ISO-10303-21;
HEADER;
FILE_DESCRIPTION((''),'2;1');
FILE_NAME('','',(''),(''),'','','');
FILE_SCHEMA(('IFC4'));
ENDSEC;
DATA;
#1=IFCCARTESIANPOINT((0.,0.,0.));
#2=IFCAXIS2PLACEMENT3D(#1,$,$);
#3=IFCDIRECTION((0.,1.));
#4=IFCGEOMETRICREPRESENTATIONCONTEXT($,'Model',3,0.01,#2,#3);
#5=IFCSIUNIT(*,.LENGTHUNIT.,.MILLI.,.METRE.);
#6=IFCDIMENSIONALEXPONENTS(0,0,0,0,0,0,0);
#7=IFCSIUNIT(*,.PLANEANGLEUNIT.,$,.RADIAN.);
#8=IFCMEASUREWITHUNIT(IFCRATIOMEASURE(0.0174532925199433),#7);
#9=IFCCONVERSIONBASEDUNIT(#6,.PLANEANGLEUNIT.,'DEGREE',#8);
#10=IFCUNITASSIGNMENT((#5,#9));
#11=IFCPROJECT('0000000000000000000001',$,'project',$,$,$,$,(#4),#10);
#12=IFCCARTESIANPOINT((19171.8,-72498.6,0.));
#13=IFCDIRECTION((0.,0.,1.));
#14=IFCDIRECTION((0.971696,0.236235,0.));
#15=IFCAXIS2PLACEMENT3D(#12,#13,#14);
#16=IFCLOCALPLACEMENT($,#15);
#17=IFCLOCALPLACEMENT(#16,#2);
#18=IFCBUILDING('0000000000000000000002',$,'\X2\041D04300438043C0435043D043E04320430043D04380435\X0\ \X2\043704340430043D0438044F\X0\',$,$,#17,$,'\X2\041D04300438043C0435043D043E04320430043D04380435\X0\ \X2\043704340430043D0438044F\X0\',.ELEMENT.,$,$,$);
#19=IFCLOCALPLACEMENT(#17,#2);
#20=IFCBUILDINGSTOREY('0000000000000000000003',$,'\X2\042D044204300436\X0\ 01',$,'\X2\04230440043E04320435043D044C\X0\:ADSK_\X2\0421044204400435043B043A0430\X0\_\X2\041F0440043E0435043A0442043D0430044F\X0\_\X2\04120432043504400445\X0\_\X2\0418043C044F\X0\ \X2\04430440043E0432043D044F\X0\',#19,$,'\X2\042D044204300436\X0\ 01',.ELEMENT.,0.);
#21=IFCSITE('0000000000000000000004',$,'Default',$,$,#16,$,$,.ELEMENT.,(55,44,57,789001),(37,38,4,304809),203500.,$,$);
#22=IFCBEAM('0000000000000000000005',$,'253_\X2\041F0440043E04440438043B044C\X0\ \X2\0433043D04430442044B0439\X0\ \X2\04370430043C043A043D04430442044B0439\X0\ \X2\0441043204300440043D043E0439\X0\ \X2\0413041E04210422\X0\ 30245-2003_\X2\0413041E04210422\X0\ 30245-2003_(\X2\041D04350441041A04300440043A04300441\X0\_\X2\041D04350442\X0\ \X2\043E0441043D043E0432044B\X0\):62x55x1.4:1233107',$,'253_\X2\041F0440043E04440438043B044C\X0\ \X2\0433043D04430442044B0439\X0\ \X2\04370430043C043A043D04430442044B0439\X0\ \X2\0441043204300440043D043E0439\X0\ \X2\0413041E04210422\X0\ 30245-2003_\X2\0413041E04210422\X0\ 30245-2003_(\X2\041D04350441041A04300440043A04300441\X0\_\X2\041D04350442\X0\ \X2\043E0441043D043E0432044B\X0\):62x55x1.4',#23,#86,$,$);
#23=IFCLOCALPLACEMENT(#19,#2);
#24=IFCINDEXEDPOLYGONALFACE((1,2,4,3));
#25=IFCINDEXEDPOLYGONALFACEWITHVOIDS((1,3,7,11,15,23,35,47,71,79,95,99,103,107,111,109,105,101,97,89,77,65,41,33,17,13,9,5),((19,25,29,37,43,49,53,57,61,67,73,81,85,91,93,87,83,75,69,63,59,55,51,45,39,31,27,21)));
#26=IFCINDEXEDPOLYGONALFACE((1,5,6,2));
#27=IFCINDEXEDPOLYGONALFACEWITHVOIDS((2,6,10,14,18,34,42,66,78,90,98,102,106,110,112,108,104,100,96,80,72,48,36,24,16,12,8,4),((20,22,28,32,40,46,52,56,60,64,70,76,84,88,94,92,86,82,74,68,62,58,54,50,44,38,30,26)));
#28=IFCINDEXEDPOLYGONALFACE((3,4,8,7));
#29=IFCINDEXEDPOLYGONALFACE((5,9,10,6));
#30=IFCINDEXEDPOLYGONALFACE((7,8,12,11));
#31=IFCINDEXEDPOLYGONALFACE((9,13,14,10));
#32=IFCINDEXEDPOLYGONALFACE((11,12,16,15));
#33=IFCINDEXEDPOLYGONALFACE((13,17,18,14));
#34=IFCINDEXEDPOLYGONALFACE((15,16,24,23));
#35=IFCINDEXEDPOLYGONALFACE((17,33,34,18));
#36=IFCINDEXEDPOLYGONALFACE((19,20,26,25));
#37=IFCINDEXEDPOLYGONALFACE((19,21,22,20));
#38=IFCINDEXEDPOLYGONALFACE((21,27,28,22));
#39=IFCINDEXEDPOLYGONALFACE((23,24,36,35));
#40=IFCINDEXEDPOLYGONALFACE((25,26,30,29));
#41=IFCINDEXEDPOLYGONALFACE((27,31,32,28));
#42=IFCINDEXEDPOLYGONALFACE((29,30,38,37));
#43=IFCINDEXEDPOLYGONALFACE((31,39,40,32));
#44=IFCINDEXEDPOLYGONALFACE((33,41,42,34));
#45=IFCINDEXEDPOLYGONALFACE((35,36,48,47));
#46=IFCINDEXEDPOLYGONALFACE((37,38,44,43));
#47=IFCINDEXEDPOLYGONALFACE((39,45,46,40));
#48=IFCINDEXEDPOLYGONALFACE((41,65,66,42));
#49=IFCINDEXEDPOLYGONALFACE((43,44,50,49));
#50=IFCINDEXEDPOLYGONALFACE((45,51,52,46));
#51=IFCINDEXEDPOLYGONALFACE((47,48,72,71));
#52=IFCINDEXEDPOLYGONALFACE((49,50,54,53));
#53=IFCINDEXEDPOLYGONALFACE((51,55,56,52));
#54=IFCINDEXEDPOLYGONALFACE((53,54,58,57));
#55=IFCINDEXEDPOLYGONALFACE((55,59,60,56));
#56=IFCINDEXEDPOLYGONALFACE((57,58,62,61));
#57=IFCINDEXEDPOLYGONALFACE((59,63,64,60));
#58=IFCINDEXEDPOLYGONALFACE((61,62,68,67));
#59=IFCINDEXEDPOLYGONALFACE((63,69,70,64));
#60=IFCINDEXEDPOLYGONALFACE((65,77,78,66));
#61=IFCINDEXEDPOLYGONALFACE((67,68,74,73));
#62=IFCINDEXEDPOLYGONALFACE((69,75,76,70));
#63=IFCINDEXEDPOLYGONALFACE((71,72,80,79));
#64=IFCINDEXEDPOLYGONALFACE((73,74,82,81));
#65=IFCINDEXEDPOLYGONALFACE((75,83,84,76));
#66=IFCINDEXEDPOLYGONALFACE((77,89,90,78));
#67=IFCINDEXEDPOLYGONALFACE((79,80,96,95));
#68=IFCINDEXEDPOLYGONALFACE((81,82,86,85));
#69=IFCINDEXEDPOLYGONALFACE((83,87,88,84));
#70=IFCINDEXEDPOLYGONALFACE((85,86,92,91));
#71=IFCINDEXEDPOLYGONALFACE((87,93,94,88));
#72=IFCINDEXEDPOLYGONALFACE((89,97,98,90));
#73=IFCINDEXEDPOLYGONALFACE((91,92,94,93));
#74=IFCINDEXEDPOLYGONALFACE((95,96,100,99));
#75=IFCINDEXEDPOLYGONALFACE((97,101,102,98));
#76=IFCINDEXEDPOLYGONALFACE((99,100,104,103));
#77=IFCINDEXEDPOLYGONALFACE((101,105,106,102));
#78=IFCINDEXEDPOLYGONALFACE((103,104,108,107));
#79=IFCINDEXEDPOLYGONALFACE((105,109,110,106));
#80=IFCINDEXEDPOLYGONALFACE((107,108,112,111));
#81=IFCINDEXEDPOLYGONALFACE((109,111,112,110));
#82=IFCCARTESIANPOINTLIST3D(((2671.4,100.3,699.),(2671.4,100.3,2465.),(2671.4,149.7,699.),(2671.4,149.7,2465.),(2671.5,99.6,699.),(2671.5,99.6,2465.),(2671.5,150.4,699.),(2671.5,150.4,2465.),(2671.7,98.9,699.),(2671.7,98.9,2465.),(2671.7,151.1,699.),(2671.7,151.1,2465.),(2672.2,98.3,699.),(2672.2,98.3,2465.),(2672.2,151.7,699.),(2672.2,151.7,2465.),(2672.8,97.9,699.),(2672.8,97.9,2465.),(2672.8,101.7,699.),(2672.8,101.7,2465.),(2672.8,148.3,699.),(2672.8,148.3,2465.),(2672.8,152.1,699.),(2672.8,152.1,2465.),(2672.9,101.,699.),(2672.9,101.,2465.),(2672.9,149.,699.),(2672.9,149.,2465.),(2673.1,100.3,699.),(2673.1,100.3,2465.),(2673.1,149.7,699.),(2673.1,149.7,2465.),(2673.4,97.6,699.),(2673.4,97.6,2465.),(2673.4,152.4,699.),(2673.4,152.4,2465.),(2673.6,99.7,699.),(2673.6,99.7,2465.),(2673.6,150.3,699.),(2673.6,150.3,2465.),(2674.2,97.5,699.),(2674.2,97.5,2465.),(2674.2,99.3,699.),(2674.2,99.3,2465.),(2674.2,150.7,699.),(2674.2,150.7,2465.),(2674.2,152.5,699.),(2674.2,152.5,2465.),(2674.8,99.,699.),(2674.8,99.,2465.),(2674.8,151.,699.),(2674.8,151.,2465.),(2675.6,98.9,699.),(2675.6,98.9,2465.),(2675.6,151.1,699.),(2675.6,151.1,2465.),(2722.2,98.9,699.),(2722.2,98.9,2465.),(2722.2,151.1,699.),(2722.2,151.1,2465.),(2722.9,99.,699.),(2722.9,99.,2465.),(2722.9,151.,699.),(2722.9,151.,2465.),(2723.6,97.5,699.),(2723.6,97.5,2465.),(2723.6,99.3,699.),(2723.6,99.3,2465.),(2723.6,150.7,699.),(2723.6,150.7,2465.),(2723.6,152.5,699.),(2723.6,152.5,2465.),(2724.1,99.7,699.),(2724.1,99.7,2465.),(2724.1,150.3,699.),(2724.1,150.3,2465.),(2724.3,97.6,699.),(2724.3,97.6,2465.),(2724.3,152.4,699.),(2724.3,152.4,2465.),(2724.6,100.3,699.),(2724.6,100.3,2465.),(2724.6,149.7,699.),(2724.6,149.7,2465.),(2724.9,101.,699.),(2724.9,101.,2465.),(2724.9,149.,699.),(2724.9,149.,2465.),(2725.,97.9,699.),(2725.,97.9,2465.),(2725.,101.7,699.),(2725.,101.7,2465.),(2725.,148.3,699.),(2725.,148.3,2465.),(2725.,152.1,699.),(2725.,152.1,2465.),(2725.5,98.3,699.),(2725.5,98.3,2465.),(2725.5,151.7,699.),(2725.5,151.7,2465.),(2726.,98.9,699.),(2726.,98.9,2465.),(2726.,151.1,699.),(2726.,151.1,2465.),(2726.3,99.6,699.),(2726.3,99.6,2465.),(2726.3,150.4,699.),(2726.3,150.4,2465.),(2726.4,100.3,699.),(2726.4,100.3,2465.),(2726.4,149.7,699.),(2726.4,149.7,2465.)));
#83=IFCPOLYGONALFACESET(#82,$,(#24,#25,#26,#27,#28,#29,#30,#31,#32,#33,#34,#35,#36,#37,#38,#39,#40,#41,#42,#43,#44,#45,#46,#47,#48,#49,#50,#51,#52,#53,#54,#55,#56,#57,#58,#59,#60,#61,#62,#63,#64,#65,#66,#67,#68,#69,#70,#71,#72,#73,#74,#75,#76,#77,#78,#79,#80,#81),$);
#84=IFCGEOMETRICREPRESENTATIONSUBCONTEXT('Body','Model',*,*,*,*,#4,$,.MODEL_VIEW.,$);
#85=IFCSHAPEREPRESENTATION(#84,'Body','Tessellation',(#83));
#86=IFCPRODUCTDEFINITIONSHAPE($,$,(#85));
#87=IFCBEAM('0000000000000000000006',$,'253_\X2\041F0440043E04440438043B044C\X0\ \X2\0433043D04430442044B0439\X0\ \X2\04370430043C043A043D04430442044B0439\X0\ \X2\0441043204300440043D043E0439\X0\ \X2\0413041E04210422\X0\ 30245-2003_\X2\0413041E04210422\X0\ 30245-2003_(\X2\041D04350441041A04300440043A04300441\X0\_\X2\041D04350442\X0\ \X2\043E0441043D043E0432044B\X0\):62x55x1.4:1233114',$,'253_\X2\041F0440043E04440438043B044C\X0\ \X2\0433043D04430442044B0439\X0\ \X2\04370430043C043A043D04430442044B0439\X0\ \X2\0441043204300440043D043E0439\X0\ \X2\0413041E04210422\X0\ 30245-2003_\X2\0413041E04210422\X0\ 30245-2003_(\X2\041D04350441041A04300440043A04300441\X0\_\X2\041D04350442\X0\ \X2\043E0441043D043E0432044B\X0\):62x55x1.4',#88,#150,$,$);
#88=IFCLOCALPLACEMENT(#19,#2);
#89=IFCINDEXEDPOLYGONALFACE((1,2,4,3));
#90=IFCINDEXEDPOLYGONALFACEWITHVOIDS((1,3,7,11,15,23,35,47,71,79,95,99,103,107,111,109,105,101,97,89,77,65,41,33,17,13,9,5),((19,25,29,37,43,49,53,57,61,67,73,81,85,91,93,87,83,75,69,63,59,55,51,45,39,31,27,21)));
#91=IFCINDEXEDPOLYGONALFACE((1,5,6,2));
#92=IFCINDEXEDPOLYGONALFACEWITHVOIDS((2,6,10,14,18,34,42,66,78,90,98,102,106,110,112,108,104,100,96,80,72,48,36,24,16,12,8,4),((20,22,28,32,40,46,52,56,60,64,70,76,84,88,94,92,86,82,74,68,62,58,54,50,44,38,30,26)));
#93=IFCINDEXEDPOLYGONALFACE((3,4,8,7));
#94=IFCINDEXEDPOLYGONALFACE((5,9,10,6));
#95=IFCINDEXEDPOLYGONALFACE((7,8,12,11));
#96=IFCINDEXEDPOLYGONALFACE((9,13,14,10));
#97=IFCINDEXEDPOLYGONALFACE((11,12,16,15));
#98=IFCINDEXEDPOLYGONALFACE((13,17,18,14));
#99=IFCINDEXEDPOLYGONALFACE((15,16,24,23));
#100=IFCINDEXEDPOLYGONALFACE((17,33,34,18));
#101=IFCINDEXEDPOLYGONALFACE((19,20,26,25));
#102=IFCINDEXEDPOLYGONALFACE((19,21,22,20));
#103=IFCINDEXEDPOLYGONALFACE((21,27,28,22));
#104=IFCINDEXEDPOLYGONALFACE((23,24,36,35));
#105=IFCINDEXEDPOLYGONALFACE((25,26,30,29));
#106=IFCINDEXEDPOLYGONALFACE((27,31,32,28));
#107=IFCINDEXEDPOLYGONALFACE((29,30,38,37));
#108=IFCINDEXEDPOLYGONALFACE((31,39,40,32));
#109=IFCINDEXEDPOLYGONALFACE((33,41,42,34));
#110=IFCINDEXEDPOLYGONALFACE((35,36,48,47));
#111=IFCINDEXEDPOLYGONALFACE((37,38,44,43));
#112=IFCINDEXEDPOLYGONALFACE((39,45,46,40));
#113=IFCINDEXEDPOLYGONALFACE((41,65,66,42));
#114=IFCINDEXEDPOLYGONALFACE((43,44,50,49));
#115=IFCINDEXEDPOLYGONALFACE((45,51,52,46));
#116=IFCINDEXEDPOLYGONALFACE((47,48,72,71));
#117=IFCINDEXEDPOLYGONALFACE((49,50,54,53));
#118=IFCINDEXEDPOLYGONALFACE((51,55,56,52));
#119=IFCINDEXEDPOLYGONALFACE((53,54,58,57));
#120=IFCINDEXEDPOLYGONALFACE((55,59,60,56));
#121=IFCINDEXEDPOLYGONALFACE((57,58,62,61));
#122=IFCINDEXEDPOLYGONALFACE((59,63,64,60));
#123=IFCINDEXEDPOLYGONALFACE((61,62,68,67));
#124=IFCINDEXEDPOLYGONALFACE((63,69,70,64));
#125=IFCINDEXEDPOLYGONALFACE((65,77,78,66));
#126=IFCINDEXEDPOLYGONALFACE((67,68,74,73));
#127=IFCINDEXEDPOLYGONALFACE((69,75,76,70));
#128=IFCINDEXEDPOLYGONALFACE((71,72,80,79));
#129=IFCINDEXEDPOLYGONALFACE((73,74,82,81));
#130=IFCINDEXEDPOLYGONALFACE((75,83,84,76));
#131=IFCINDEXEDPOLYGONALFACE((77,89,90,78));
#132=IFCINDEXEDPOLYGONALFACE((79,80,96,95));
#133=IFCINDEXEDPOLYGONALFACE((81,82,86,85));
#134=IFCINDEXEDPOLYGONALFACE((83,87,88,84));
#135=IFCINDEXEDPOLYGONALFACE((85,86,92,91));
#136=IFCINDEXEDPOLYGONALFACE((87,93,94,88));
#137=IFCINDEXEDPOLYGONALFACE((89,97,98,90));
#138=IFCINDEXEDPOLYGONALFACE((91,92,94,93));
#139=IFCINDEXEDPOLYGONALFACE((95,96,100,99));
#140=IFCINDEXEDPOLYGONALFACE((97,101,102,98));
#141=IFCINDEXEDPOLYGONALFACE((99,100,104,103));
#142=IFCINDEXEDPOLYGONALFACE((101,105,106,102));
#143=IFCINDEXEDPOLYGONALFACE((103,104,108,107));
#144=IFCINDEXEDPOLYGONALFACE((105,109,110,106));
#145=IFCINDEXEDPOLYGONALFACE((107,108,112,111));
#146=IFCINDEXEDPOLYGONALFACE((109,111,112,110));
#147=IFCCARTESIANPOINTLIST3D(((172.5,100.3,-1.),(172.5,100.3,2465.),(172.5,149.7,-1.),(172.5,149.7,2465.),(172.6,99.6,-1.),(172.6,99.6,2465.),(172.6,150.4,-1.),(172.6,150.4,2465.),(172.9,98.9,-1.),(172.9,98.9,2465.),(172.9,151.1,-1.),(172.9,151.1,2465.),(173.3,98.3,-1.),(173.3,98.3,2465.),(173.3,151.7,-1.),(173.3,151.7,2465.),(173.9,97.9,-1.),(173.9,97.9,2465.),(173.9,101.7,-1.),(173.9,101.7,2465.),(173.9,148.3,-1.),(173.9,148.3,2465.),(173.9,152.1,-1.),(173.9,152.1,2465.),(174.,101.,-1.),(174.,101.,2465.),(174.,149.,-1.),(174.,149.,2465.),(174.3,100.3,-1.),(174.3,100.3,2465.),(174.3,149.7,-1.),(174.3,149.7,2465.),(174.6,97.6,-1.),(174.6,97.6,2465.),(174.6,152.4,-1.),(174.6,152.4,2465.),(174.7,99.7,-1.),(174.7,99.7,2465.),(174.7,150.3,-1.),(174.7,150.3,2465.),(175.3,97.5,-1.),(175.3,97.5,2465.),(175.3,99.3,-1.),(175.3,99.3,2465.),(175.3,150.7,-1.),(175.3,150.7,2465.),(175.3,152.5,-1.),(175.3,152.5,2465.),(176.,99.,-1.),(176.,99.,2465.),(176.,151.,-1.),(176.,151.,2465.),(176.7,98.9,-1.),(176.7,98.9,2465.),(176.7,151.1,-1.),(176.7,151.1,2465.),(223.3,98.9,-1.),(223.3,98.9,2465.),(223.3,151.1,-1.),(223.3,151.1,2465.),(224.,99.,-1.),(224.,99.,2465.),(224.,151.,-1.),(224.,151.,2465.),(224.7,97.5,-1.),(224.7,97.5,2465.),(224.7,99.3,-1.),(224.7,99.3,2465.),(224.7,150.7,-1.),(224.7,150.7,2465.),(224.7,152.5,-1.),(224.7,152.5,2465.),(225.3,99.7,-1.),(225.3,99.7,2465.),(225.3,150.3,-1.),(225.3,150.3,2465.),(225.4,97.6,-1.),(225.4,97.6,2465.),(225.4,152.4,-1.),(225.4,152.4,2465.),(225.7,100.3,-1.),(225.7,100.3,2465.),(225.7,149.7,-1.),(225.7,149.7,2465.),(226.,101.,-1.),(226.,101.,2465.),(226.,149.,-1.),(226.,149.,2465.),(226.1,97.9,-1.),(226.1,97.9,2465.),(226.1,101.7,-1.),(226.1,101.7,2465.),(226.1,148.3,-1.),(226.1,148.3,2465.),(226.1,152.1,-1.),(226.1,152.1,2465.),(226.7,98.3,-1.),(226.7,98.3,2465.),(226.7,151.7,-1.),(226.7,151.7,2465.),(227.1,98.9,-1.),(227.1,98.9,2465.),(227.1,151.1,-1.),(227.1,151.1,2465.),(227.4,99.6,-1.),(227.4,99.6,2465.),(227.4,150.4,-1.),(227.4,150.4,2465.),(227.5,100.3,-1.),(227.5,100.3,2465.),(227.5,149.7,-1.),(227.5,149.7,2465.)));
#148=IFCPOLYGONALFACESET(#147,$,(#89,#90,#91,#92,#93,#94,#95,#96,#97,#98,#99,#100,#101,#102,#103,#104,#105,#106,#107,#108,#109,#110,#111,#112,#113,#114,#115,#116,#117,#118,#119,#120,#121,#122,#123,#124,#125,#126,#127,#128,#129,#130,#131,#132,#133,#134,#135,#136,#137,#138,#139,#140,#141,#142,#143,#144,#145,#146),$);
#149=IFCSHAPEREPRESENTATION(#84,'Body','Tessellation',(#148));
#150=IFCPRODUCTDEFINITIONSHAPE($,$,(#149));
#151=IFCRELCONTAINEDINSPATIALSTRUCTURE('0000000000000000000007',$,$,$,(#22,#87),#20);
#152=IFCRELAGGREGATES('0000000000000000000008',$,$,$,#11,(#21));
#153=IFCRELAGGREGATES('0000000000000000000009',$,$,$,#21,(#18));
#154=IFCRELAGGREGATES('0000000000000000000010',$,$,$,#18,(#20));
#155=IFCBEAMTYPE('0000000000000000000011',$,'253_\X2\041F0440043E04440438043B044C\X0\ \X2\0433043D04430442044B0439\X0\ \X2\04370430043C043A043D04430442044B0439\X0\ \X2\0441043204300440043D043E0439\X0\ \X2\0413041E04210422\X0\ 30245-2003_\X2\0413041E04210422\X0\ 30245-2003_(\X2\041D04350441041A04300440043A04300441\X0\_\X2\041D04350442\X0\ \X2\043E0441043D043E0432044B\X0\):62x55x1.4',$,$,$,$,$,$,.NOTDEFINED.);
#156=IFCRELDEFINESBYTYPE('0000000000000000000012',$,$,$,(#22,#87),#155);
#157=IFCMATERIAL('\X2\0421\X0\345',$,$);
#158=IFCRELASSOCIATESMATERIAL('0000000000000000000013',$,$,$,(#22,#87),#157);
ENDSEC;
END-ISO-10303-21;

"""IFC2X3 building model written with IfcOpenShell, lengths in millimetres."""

from ifc_helpers import new_model, entity, si_unit, converted_unit, direction, frame, frame_2d, origin, place, context, subcontext, project, spatial, polyline, circle_curve, parameter, trimmed, segment, composite_curve, outline, extrude, material, type_object, element, save


model = new_model("IFC2X3")

# Units and contexts
model_context = context("Model", 3, precision=0.01, world=origin(), true_north=direction((0.0, 1.0)))
body_context = subcontext(model_context, "Body", "Model", "MODEL_VIEW")
ifc_project = project(units=[si_unit("LENGTHUNIT", "METRE", prefix="MILLI"), converted_unit("PLANEANGLEUNIT", "DEGREE", entity("IfcRatioMeasure", 0.0174532925199433), si_unit("PLANEANGLEUNIT", "RADIAN"), dimensions=[0, 0, 0, 0, 0, 0, 0])], contexts=[model_context])

# Site, building, storey
site_placement = place(None, frame((19171.8, -72498.6, 0.0), z_axis=(0.0, 0.0, 1.0), x_axis=(0.971696, 0.236235, 0.0)))
site = spatial("IfcSite", under=ifc_project, at=site_placement, Name="Default", CompositionType="ELEMENT", RefLatitude=(55, 44, 57, 789001), RefLongitude=(37, 38, 4, 304809), RefElevation=203500.0)
building_placement = place(site_placement, origin())
building = spatial("IfcBuilding", under=site, at=building_placement, Name="Наименование здания", LongName="Наименование здания", CompositionType="ELEMENT")
storey_placement = place(building_placement, origin())
storey = spatial("IfcBuildingStorey", under=building, at=storey_placement, Name="Этаж 01", ObjectType="Уровень:ADSK_Стрелка_Проектная_Вверх_Имя уровня", LongName="Этаж 01", CompositionType="ELEMENT", Elevation=0.0)

# Beams
ifc_material_1 = material(Name="С345")
beam_type_1 = type_object("IfcBeamType", Name="253_Профиль гнутый замкнутый сварной ГОСТ 30245-2003_ГОСТ 30245-2003_(НесКаркас_Нет основы):62x55x1.4", PredefinedType="NOTDEFINED")
beam_1_placement = place(storey_placement, frame((2669.8, 95.9, 699.0), z_axis=(1.0, 0.0, 0.0), x_axis=(0.0, 0.0, 1.0)))
element("IfcBeam", 1, at=beam_1_placement, inside=storey, type_object=beam_type_1, material=ifc_material_1, Name="253_Профиль гнутый замкнутый сварной ГОСТ 30245-2003_ГОСТ 30245-2003_(НесКаркас_Нет основы):62x55x1.4:1233107", ObjectType="253_Профиль гнутый замкнутый сварной ГОСТ 30245-2003_ГОСТ 30245-2003_(НесКаркас_Нет основы):62x55x1.4", context=body_context, shape_type="SweptSolid", body=[
    extrude(outline(composite_curve([segment(trimmed(circle_curve(frame_2d((24.7, -24.7), x_axis=(1.0, 0.0)), 2.8), [parameter(270.0)], [parameter(0.0)], True, "PARAMETER"), True, "CONTINUOUS"), segment(polyline([(27.5, -24.7), (27.5, 24.7)]), True, "CONTINUOUS"), segment(trimmed(circle_curve(frame_2d((24.7, 24.7), x_axis=(1.0, 0.0)), 2.8), [parameter(0.0)], [parameter(90.0)], True, "PARAMETER"), True, "CONTINUOUS"), segment(polyline([(24.7, 27.5), (-24.7, 27.5)]), True, "CONTINUOUS"), segment(trimmed(circle_curve(frame_2d((-24.7, 24.7), x_axis=(1.0, 0.0)), 2.8), [parameter(90.0)], [parameter(180.0)], True, "PARAMETER"), True, "CONTINUOUS"), segment(polyline([(-27.5, 24.7), (-27.5, -24.7)]), True, "CONTINUOUS"), segment(trimmed(circle_curve(frame_2d((-24.7, -24.7), x_axis=(1.0, 0.0)), 2.8), [parameter(180.0)], [parameter(270.0)], True, "PARAMETER"), True, "CONTINUOUS"), segment(polyline([(-24.7, -27.5), (24.7, -27.5)]), True, "CONTINUOUS")], self_intersect=False), holes=[composite_curve([segment(polyline([(23.3, -26.1), (-23.3, -26.1)]), True, "CONTINUOUS"), segment(trimmed(circle_curve(frame_2d((-23.3, -23.3), x_axis=(1.0, 0.0)), 2.8), [parameter(180.0)], [parameter(270.0)], True, "PARAMETER"), False, "CONTINUOUS"), segment(polyline([(-26.1, -23.3), (-26.1, 23.3)]), True, "CONTINUOUS"), segment(trimmed(circle_curve(frame_2d((-23.3, 23.3), x_axis=(1.0, 0.0)), 2.8), [parameter(90.0)], [parameter(180.0)], True, "PARAMETER"), False, "CONTINUOUS"), segment(polyline([(-23.3, 26.1), (23.3, 26.1)]), True, "CONTINUOUS"), segment(trimmed(circle_curve(frame_2d((23.3, 23.3), x_axis=(1.0, 0.0)), 2.8), [parameter(0.0)], [parameter(90.0)], True, "PARAMETER"), False, "CONTINUOUS"), segment(polyline([(26.1, 23.3), (26.1, -23.3)]), True, "CONTINUOUS"), segment(trimmed(circle_curve(frame_2d((23.3, -23.3), x_axis=(1.0, 0.0)), 2.8), [parameter(270.0)], [parameter(0.0)], True, "PARAMETER"), False, "CONTINUOUS")], self_intersect=False)]), frame((0.0, -29.1, 29.1), z_axis=(1.0, 0.0, 0.0), x_axis=(0.0, -1.0, 0.0)), (0.0, 0.0, 1.0), 1766.0),
])
beam_2_placement = place(storey_placement, frame((170.9, 95.9, -1.0), z_axis=(1.0, 0.0, 0.0), x_axis=(0.0, 0.0, 1.0)))
element("IfcBeam", 2, at=beam_2_placement, inside=storey, type_object=beam_type_1, material=ifc_material_1, Name="253_Профиль гнутый замкнутый сварной ГОСТ 30245-2003_ГОСТ 30245-2003_(НесКаркас_Нет основы):62x55x1.4:1233114", ObjectType="253_Профиль гнутый замкнутый сварной ГОСТ 30245-2003_ГОСТ 30245-2003_(НесКаркас_Нет основы):62x55x1.4", context=body_context, shape_type="SweptSolid", body=[
    extrude(outline(composite_curve([segment(trimmed(circle_curve(frame_2d((24.7, -24.7), x_axis=(1.0, 0.0)), 2.8), [parameter(270.0)], [parameter(0.0)], True, "PARAMETER"), True, "CONTINUOUS"), segment(polyline([(27.5, -24.7), (27.5, 24.7)]), True, "CONTINUOUS"), segment(trimmed(circle_curve(frame_2d((24.7, 24.7), x_axis=(1.0, 0.0)), 2.8), [parameter(0.0)], [parameter(90.0)], True, "PARAMETER"), True, "CONTINUOUS"), segment(polyline([(24.7, 27.5), (-24.7, 27.5)]), True, "CONTINUOUS"), segment(trimmed(circle_curve(frame_2d((-24.7, 24.7), x_axis=(1.0, 0.0)), 2.8), [parameter(90.0)], [parameter(180.0)], True, "PARAMETER"), True, "CONTINUOUS"), segment(polyline([(-27.5, 24.7), (-27.5, -24.7)]), True, "CONTINUOUS"), segment(trimmed(circle_curve(frame_2d((-24.7, -24.7), x_axis=(1.0, 0.0)), 2.8), [parameter(180.0)], [parameter(270.0)], True, "PARAMETER"), True, "CONTINUOUS"), segment(polyline([(-24.7, -27.5), (24.7, -27.5)]), True, "CONTINUOUS")], self_intersect=False), holes=[composite_curve([segment(polyline([(23.3, -26.1), (-23.3, -26.1)]), True, "CONTINUOUS"), segment(trimmed(circle_curve(frame_2d((-23.3, -23.3), x_axis=(1.0, 0.0)), 2.8), [parameter(180.0)], [parameter(270.0)], True, "PARAMETER"), False, "CONTINUOUS"), segment(polyline([(-26.1, -23.3), (-26.1, 23.3)]), True, "CONTINUOUS"), segment(trimmed(circle_curve(frame_2d((-23.3, 23.3), x_axis=(1.0, 0.0)), 2.8), [parameter(90.0)], [parameter(180.0)], True, "PARAMETER"), False, "CONTINUOUS"), segment(polyline([(-23.3, 26.1), (23.3, 26.1)]), True, "CONTINUOUS"), segment(trimmed(circle_curve(frame_2d((23.3, 23.3), x_axis=(1.0, 0.0)), 2.8), [parameter(0.0)], [parameter(90.0)], True, "PARAMETER"), False, "CONTINUOUS"), segment(polyline([(26.1, 23.3), (26.1, -23.3)]), True, "CONTINUOUS"), segment(trimmed(circle_curve(frame_2d((23.3, -23.3), x_axis=(1.0, 0.0)), 2.8), [parameter(270.0)], [parameter(0.0)], True, "PARAMETER"), False, "CONTINUOUS")], self_intersect=False)]), frame((0.0, -29.1, 29.1), z_axis=(1.0, 0.0, 0.0), x_axis=(0.0, -1.0, 0.0)), (0.0, 0.0, 1.0), 2466.0),
])

save(model, "model.ifc")
